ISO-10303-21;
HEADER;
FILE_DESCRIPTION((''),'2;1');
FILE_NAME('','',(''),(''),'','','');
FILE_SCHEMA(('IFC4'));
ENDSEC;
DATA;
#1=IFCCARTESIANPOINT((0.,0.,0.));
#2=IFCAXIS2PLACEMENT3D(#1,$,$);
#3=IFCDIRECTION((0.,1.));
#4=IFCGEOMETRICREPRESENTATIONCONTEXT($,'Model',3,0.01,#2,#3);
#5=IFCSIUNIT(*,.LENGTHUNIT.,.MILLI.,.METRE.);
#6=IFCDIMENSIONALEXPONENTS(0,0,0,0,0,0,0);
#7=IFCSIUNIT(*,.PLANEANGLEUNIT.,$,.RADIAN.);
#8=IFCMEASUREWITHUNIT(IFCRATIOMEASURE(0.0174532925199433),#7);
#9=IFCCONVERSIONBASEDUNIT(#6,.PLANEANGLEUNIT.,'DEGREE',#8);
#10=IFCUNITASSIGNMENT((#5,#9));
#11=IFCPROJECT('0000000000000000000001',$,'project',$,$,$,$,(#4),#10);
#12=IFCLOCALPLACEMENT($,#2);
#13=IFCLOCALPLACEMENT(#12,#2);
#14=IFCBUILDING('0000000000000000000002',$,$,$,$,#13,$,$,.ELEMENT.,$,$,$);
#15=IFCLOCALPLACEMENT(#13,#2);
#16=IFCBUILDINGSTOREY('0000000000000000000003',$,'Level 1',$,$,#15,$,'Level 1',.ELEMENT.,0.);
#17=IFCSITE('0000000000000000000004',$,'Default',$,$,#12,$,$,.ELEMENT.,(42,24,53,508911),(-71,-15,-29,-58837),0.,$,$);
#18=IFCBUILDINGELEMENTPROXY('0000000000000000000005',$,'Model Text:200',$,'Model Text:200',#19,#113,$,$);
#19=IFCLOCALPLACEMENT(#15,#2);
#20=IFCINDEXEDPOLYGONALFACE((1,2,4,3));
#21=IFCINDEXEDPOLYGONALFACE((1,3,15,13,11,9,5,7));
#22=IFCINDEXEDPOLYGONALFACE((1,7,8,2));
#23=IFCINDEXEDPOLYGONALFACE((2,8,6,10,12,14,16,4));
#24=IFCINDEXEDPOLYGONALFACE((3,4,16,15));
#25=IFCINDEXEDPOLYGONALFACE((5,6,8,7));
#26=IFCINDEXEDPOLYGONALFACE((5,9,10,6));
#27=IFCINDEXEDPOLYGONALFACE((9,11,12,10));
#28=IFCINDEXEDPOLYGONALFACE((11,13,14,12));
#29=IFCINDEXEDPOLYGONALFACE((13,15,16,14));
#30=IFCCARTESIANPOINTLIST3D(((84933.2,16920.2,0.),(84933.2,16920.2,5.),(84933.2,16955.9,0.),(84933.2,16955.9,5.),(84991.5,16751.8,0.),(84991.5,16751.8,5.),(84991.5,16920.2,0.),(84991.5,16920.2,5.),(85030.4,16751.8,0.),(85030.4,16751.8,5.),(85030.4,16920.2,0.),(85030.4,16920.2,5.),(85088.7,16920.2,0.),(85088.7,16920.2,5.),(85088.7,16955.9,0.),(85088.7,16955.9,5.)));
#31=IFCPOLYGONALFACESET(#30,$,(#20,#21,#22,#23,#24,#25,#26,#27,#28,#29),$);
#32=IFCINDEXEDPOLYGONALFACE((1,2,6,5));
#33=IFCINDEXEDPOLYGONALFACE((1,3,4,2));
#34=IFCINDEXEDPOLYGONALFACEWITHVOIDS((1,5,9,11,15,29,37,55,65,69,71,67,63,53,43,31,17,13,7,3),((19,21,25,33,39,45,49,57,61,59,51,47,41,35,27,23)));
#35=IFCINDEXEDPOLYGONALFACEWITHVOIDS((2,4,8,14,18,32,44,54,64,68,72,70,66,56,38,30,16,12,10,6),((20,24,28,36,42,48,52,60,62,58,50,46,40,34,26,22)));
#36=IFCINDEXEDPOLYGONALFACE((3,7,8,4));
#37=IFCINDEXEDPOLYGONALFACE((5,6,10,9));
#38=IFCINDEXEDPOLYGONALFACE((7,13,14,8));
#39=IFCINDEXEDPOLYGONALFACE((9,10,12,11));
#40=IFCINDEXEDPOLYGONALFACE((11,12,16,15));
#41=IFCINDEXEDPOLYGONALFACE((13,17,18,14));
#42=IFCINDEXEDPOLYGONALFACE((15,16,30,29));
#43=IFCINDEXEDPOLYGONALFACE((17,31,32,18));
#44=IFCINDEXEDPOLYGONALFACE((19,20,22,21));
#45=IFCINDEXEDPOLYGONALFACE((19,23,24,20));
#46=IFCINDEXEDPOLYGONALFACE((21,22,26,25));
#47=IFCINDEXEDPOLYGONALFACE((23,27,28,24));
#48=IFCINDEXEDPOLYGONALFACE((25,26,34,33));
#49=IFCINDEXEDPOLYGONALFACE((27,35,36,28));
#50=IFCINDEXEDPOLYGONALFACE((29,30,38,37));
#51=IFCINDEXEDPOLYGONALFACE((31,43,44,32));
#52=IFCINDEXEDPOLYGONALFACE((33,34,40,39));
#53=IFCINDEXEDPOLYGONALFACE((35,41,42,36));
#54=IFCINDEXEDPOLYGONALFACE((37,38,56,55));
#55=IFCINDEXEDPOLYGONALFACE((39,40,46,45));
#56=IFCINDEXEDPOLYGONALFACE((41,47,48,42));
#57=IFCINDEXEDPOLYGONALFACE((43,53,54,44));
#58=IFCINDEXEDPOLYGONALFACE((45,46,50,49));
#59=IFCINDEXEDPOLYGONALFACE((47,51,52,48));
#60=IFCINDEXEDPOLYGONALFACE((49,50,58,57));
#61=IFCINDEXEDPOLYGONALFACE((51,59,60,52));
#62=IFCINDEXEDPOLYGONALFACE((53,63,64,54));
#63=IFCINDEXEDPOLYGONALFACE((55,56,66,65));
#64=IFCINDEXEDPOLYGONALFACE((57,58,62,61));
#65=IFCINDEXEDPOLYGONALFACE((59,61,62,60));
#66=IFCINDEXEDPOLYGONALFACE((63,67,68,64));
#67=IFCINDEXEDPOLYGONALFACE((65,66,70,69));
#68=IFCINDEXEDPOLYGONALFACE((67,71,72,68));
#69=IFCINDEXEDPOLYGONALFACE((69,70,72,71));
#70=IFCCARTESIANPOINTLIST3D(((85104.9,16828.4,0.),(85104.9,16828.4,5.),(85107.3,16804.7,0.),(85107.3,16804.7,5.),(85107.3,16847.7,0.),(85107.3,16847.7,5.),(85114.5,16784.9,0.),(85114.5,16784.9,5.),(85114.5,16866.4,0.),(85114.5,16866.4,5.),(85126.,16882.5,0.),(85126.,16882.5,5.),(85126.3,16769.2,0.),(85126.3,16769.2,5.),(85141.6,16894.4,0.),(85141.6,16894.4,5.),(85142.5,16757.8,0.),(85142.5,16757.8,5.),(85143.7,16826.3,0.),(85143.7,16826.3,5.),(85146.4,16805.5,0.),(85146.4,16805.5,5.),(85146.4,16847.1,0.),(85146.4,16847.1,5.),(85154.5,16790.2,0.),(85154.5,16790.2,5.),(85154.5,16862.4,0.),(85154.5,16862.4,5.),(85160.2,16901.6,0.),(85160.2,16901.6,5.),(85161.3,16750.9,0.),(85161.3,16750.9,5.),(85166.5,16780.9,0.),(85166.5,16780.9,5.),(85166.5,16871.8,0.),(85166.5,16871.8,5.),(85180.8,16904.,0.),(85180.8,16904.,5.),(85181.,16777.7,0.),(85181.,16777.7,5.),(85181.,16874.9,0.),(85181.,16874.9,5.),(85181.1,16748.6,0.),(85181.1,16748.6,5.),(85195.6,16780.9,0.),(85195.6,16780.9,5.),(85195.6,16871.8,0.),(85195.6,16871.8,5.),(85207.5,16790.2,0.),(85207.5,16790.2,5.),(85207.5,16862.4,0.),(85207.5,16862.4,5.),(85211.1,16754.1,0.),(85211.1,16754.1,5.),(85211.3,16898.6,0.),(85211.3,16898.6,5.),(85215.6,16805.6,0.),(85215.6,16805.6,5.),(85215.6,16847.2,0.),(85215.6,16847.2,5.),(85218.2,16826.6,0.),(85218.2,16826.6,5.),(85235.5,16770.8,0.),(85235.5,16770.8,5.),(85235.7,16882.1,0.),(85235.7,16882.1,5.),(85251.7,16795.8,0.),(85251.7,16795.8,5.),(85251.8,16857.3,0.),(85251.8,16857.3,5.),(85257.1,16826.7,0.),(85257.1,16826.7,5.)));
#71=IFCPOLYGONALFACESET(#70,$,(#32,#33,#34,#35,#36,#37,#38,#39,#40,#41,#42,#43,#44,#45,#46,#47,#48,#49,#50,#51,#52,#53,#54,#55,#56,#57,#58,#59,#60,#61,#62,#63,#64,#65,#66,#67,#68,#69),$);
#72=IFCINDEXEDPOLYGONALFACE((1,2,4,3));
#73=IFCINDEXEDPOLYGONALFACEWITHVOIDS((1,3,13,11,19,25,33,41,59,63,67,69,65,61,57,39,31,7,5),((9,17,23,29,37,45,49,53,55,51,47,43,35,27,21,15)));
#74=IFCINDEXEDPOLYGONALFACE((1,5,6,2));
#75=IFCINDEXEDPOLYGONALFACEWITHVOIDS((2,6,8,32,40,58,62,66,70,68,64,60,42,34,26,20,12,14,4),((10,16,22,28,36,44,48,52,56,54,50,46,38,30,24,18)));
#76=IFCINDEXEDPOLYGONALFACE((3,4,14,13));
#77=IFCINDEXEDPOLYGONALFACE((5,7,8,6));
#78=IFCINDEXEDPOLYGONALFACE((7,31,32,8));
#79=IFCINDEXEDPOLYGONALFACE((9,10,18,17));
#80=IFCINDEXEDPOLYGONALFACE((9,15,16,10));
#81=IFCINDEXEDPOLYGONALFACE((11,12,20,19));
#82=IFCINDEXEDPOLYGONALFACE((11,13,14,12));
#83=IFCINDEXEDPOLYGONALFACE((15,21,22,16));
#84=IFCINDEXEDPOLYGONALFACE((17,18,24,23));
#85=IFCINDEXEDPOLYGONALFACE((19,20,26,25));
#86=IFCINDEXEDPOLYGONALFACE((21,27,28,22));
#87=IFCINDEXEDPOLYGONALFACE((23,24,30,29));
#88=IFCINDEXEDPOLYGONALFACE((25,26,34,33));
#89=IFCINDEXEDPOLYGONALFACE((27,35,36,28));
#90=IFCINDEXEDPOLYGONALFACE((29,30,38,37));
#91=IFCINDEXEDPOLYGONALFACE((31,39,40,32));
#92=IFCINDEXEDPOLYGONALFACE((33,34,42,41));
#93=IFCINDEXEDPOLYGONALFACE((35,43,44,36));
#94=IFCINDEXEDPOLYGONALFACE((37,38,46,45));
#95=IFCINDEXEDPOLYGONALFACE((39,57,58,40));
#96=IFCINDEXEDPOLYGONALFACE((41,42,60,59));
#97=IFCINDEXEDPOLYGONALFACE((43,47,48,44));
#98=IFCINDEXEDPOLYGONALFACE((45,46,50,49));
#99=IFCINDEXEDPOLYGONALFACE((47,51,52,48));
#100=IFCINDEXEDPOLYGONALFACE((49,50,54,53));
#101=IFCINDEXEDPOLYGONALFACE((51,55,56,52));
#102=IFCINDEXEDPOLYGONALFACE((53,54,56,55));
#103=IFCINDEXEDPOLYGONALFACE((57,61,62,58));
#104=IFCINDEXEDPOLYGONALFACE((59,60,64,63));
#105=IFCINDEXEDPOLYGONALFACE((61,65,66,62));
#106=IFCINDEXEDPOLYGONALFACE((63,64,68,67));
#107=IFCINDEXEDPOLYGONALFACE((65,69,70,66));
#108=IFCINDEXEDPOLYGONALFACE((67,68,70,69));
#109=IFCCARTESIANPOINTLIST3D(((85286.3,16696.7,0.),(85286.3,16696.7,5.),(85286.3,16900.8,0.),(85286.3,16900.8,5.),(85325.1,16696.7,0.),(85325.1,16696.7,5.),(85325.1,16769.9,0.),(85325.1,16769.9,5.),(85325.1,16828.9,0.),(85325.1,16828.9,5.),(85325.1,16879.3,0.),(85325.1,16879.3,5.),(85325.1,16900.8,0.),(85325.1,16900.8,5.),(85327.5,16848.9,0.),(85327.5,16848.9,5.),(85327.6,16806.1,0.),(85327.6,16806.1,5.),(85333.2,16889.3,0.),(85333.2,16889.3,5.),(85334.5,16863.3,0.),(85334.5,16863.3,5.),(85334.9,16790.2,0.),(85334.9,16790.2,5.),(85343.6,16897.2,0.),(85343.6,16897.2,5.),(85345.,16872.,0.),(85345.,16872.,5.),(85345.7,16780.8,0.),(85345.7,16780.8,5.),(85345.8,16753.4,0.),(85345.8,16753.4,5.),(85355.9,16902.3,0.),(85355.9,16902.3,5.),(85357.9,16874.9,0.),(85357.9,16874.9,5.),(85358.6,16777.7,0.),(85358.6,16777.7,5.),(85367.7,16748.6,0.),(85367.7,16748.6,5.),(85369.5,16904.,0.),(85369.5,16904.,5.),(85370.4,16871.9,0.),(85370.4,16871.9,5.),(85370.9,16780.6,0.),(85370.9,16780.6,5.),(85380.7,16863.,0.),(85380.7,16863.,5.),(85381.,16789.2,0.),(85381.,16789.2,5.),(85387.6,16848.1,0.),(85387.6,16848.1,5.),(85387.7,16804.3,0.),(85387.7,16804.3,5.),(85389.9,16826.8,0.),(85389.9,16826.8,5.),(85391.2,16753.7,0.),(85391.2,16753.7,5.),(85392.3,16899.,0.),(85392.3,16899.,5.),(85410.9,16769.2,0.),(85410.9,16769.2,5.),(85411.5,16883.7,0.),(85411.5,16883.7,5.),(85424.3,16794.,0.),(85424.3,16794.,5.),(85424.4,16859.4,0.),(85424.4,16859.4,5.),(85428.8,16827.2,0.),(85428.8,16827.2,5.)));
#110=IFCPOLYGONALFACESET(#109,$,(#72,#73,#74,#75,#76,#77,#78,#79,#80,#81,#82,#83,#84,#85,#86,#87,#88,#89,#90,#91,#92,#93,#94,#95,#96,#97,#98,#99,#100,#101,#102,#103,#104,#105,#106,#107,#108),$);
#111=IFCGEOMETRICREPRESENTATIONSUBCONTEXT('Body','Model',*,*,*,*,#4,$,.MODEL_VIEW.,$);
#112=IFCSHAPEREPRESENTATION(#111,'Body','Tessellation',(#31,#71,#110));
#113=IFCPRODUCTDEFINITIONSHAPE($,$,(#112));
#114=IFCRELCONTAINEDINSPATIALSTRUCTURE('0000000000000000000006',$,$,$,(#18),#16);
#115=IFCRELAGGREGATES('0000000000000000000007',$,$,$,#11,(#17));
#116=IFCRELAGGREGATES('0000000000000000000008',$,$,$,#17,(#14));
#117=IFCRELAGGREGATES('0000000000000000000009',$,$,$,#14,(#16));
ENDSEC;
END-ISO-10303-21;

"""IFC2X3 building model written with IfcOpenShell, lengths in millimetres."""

from ifc_helpers import new_model, entity, si_unit, converted_unit, direction, frame, origin, place, context, subcontext, project, spatial, polyline, outline, extrude, element, save


model = new_model("IFC2X3")

# Units and contexts
model_context = context("Model", 3, precision=0.01, world=origin(), true_north=direction((0.0, 1.0)))
body_context = subcontext(model_context, "Body", "Model", "MODEL_VIEW")
ifc_project = project(units=[si_unit("LENGTHUNIT", "METRE", prefix="MILLI"), converted_unit("PLANEANGLEUNIT", "DEGREE", entity("IfcRatioMeasure", 0.0174532925199433), si_unit("PLANEANGLEUNIT", "RADIAN"), dimensions=[0, 0, 0, 0, 0, 0, 0])], contexts=[model_context])

# Site, building, storey
site_placement = place(None, origin())
site = spatial("IfcSite", under=ifc_project, at=site_placement, Name="Default", CompositionType="ELEMENT", RefLatitude=(42, 24, 53, 508911), RefLongitude=(-71, -15, -29, -58837), RefElevation=0.0)
building_placement = place(site_placement, origin())
building = spatial("IfcBuilding", under=site, at=building_placement, CompositionType="ELEMENT")
storey_placement = place(building_placement, origin())
storey = spatial("IfcBuildingStorey", under=building, at=storey_placement, Name="Level 1", LongName="Level 1", CompositionType="ELEMENT", Elevation=0.0)

# Building element proxy
proxy_1_placement = place(storey_placement, origin())
element("IfcBuildingElementProxy", 1, at=proxy_1_placement, inside=storey, Name="Model Text:200", ObjectType="Model Text:200", context=body_context, shape_type="SweptSolid", body=[
    extrude(outline(polyline([(-19.4, -135.2), (19.4, -135.2), (19.4, 33.2), (77.7, 33.2), (77.7, 68.8), (-77.7, 68.8), (-77.7, 33.2), (-19.4, 33.2), (-19.4, -135.2)])), frame((85010.9, 16887.0, 0.0)), (0.0, 0.0, 1.0), 5.0),
    extrude(outline(polyline([(-8.8, -65.7), (15.1, -65.7), (35.5, -60.5), (52.3, -50.4), (65.3, -35.4), (74.1, -17.3), (78.4, 2.1), (75.9, 32.5), (61.8, 58.5), (38.4, 77.1), (8.3, 85.6), (-22.7, 83.3), (-49.0, 69.9), (-67.8, 47.3), (-76.3, 17.5), (-76.0, -3.3), (-70.7, -22.5), (-60.5, -39.2), (-45.5, -52.3), (-27.7, -61.4), (-8.8, -65.7)]), holes=[polyline([(-2.7, -27.2), (-23.1, -22.5), (-37.5, -12.9), (-45.7, 0.0), (-47.3, 14.8), (-42.7, 28.9), (-32.2, 39.9), (-16.3, 46.3), (4.5, 46.9), (25.1, 42.1), (39.6, 32.6), (47.7, 19.7), (49.4, 5.0), (44.8, -9.2), (34.2, -20.2), (18.2, -26.7), (-2.7, -27.2)])]), frame((85171.1, 16826.3, 0.0), z_axis=(0.0, 0.0, 1.0), x_axis=(0.100608, -0.994926, 0.0)), (0.0, 0.0, 1.0), 5.0),
    extrude(outline(polyline([(-73.1, -75.4), (130.9, -75.4), (130.9, -36.6), (57.8, -36.6), (74.3, -15.9), (79.1, 6.0), (73.9, 29.5), (58.4, 49.2), (33.6, 62.6), (0.5, 67.1), (-31.8, 62.8), (-56.1, 49.8), (-71.3, 30.7), (-76.4, 7.8), (-74.7, -5.8), (-69.6, -18.1), (-61.7, -28.5), (-51.7, -36.6), (-73.1, -36.6), (-73.1, -75.4)]), holes=[polyline([(-1.2, -36.6), (-21.2, -34.2), (-35.6, -27.2), (-44.3, -16.7), (-47.2, -3.8), (-44.3, 8.7), (-35.4, 19.0), (-20.4, 25.9), (0.8, 28.2), (23.3, 26.0), (38.5, 19.3), (47.1, 9.2), (49.9, -3.1), (46.8, -16.0), (37.4, -26.8), (21.5, -34.1), (-1.2, -36.6)])]), frame((85361.7, 16827.7, 0.0), z_axis=(0.0, 0.0, 1.0), x_axis=(0.0, -1.0, 0.0)), (0.0, 0.0, 1.0), 5.0),
])

save(model, "model.ifc")
